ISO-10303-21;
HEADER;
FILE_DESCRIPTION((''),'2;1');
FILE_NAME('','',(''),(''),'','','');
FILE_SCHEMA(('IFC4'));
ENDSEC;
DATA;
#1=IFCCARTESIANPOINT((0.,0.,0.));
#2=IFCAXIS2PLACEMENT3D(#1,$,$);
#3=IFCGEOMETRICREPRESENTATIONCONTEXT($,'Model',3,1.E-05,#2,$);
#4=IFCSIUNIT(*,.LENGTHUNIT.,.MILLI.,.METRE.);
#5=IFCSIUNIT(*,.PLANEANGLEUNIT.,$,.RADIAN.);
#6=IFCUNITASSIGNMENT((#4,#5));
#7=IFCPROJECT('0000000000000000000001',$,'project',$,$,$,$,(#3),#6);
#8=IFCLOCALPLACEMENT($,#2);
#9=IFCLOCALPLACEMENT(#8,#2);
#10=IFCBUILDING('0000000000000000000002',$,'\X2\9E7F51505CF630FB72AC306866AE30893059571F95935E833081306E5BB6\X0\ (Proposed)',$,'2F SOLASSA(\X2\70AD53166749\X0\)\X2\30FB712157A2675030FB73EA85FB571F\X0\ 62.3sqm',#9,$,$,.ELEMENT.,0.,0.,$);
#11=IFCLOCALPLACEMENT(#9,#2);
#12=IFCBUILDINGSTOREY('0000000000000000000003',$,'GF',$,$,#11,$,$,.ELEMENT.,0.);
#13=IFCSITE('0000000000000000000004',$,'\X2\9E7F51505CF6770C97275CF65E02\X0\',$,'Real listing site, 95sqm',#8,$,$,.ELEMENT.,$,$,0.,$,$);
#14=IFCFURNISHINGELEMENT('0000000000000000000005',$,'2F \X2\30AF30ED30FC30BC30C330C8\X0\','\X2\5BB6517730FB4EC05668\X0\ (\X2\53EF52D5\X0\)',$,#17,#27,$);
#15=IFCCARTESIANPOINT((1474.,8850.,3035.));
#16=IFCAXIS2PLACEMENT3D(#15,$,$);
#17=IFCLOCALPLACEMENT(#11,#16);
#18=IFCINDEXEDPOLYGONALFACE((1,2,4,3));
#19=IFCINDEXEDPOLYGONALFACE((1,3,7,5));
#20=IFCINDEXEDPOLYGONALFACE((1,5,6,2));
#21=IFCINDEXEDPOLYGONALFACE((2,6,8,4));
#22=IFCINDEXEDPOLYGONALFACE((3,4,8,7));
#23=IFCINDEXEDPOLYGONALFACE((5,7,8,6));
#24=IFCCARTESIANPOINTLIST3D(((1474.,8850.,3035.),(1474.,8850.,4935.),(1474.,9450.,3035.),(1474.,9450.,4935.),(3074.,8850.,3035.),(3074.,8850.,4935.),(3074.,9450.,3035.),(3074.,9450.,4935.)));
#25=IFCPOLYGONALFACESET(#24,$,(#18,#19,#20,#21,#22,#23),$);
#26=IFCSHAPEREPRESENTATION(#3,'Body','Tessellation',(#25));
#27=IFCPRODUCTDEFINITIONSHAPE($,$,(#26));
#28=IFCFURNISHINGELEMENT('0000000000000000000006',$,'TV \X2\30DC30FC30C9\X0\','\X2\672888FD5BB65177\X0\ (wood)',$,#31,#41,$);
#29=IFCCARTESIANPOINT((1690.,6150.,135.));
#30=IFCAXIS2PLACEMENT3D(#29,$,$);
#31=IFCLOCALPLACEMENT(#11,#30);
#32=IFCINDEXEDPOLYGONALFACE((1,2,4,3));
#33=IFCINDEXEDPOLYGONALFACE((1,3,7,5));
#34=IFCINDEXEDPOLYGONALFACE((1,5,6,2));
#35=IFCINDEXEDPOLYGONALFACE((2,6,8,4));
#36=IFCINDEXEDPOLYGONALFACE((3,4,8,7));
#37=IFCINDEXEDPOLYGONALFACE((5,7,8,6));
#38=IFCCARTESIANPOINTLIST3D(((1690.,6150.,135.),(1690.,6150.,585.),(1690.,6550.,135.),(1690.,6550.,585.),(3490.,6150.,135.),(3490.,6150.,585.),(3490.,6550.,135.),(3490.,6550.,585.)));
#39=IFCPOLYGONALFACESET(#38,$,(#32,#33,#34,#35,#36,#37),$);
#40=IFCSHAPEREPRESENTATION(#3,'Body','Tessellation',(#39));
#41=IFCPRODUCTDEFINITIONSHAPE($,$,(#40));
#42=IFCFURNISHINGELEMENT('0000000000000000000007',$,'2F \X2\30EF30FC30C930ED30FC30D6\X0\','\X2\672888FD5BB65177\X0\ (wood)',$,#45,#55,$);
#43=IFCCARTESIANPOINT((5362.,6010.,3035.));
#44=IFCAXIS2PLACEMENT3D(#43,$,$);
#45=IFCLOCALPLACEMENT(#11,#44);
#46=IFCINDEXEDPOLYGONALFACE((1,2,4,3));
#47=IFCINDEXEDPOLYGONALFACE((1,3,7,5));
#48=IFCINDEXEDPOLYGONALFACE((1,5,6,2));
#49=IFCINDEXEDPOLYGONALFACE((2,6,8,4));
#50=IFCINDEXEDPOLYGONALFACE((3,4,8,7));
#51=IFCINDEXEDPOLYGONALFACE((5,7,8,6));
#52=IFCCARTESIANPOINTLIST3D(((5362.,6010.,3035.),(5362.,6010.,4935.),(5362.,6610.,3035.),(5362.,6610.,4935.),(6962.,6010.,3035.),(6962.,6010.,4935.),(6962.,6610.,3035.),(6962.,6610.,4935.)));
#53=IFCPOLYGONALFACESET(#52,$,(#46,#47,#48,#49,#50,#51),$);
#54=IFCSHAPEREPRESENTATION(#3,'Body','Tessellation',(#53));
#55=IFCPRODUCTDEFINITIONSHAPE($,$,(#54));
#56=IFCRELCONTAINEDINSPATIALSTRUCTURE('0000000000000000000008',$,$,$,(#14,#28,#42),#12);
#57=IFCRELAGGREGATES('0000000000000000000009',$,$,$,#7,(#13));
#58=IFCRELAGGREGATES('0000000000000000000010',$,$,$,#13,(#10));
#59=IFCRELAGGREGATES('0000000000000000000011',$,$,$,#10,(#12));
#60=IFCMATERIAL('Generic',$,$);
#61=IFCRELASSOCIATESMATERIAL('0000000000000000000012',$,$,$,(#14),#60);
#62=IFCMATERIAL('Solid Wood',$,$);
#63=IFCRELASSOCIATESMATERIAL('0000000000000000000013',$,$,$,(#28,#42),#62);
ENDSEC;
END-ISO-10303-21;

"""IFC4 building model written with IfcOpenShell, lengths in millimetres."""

from ifc_helpers import new_model, si_unit, frame, frame_2d, origin, place, context, project, spatial, rectangle, extrude, material, element, save


model = new_model("IFC4")

# Units and contexts
model_context = context("Model", 3, precision=1e-05, world=origin())
ifc_project = project(units=[si_unit("LENGTHUNIT", "METRE", prefix="MILLI"), si_unit("PLANEANGLEUNIT", "RADIAN")], contexts=[model_context])

# Site, building, storey
site_placement = place(None, origin())
site = spatial("IfcSite", under=ifc_project, at=site_placement, Name="鹿児島県霧島市", ObjectType="Real listing site, 95sqm", CompositionType="ELEMENT", RefElevation=0.0)
building_placement = place(site_placement, origin())
building = spatial("IfcBuilding", under=site, at=building_placement, Name="鹿児島・犬と暮らす土間広めの家 (Proposed)", ObjectType="2F SOLASSA(炭化杉)・無垢材・珪藻土 62.3sqm", CompositionType="ELEMENT", ElevationOfRefHeight=0.0, ElevationOfTerrain=0.0)
storey_placement = place(building_placement, origin())
storey = spatial("IfcBuildingStorey", under=building, at=storey_placement, Name="GF", CompositionType="ELEMENT", Elevation=0.0)

# Shared definitions
ifc_material_1 = material(Name="Solid Wood")

# Shared definitions
ifc_material_2 = material(Name="Generic")

# Furnishing elements
furnishing_1_placement = place(storey_placement, frame((1474.0, 8850.0, 3035.0)))
element("IfcFurnishingElement", 1, at=furnishing_1_placement, inside=storey, material=ifc_material_2, Name="2F クローゼット", Description="家具・什器 (可動)", context=model_context, shape_type="SweptSolid", body=[
    extrude(rectangle(XDim=1600.0, YDim=600.0, at=frame_2d((800.0, 300.0))), frame((1474.0, 8850.0, 3035.0)), (0.0, 0.0, 1.0), 1900.0),
])
furnishing_2_placement = place(storey_placement, frame((1690.0, 6150.0, 135.0)))
element("IfcFurnishingElement", 2, at=furnishing_2_placement, inside=storey, material=ifc_material_1, Name="TV ボード", Description="木製家具 (wood)", context=model_context, shape_type="SweptSolid", body=[
    extrude(rectangle(XDim=1800.0, YDim=400.0, at=frame_2d((900.0, 200.0))), frame((1690.0, 6150.0, 135.0)), (0.0, 0.0, 1.0), 450.0),
])
furnishing_3_placement = place(storey_placement, frame((5362.0, 6010.0, 3035.0)))
element("IfcFurnishingElement", 3, at=furnishing_3_placement, inside=storey, material=ifc_material_1, Name="2F ワードローブ", Description="木製家具 (wood)", context=model_context, shape_type="SweptSolid", body=[
    extrude(rectangle(XDim=1600.0, YDim=600.0, at=frame_2d((800.0, 300.0))), frame((5362.0, 6010.0, 3035.0)), (0.0, 0.0, 1.0), 1900.0),
])

save(model, "model.ifc")
